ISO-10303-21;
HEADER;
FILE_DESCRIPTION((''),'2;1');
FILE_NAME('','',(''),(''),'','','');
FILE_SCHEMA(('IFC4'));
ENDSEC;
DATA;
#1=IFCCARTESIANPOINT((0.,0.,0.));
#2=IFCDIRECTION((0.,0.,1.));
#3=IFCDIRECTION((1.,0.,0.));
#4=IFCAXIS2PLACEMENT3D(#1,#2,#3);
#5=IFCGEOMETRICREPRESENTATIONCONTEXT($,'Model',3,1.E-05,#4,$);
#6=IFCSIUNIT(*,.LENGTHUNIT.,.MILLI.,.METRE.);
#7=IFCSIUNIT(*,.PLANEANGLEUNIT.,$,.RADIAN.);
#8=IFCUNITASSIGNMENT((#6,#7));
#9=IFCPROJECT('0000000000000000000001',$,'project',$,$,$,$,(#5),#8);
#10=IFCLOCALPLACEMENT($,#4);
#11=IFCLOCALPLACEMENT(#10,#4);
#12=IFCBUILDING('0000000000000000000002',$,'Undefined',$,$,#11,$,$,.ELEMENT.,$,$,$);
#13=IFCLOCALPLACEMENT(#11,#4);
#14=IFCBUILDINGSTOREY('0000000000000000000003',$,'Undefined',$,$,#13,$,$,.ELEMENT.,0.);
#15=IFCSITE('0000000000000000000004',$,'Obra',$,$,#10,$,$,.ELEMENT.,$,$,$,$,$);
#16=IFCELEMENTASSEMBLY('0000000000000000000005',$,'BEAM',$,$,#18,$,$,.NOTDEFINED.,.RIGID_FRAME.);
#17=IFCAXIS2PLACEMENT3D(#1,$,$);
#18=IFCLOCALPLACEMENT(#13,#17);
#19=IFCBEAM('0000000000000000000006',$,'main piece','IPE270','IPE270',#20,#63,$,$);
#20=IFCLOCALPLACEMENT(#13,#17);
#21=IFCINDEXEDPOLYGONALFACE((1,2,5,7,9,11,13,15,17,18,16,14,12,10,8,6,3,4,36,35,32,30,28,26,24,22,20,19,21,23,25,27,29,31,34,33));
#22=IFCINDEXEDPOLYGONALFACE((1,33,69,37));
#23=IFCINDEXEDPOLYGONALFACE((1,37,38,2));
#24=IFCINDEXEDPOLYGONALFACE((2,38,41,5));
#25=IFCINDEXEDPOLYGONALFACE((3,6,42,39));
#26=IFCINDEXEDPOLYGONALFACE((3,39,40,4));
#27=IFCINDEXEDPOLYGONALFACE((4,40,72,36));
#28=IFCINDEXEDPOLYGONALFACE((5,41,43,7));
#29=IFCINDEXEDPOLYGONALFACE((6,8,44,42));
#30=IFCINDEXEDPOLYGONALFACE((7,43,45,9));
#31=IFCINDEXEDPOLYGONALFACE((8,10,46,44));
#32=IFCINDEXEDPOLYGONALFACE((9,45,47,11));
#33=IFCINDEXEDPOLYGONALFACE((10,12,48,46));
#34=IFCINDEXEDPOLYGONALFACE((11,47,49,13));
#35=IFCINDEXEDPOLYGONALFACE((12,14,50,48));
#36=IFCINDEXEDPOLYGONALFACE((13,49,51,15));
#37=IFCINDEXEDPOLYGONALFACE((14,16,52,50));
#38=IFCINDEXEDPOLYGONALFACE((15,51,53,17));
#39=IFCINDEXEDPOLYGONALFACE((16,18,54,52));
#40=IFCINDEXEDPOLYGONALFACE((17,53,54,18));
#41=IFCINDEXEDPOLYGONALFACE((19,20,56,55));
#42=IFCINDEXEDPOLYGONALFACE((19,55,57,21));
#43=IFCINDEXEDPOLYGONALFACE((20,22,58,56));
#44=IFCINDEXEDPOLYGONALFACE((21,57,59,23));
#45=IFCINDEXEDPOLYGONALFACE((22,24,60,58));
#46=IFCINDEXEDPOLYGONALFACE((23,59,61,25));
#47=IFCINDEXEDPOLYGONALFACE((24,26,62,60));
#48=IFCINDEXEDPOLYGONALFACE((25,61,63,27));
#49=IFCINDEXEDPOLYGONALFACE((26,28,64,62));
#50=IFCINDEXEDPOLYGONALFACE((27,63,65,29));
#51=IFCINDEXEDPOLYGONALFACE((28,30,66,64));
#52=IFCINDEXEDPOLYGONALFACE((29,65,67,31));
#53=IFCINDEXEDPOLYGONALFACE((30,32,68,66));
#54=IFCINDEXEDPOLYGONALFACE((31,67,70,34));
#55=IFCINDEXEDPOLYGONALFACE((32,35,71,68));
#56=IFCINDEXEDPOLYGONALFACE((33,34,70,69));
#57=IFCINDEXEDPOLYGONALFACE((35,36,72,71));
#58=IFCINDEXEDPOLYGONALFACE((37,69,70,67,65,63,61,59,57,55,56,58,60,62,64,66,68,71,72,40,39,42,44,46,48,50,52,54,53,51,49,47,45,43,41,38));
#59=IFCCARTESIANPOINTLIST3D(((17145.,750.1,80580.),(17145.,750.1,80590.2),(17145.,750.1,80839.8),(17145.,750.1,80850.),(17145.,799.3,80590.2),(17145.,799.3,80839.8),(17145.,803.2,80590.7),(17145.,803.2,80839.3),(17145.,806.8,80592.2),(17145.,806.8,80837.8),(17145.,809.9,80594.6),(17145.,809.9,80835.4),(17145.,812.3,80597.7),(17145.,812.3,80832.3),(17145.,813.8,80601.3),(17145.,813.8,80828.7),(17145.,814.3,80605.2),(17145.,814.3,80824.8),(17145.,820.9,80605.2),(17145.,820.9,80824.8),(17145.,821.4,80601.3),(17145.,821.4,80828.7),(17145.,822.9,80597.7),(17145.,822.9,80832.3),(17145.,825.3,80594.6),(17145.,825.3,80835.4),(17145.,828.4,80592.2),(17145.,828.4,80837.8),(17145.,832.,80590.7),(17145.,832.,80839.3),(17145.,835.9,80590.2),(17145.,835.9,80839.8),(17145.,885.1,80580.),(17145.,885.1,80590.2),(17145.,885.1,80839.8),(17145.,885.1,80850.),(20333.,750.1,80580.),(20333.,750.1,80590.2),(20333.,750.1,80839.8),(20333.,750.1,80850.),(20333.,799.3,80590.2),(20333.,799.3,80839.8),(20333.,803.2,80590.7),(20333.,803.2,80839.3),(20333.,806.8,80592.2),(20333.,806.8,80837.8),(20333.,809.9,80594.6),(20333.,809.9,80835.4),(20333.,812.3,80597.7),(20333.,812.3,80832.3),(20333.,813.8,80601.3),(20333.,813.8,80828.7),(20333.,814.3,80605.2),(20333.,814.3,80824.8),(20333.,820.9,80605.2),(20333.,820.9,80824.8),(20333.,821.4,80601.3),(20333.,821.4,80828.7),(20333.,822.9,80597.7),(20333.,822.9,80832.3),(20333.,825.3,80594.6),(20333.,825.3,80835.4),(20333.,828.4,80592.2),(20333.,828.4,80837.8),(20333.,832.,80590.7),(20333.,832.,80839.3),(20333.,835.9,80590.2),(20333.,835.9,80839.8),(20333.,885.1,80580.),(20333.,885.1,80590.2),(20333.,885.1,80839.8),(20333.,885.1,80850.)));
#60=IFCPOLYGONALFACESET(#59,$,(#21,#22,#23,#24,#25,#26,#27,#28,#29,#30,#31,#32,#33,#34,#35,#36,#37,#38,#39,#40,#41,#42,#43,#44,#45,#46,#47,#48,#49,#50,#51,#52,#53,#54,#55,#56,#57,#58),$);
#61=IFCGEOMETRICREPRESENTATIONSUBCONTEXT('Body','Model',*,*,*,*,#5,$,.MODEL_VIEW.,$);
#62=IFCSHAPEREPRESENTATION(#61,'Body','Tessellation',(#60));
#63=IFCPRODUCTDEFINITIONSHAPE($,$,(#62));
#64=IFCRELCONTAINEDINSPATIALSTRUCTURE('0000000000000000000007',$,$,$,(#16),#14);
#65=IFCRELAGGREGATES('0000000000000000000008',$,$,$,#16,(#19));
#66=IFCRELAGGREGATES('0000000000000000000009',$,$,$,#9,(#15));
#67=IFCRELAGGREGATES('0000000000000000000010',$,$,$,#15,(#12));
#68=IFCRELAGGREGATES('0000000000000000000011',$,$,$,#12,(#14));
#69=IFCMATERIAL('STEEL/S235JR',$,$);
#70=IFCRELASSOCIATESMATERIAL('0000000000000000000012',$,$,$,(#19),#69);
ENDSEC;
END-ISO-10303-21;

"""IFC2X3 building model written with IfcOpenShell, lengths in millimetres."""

from ifc_helpers import new_model, si_unit, frame, origin_with_axes, origin_2d_with_axis, place, context, subcontext, project, spatial, i_section, extrude, material, element, aggregate, save


model = new_model("IFC2X3")

# Units and contexts
model_context = context("Model", 3, precision=1e-05, world=origin_with_axes())
body_context = subcontext(model_context, "Body", "Model", "MODEL_VIEW")
ifc_project = project(units=[si_unit("LENGTHUNIT", "METRE", prefix="MILLI"), si_unit("PLANEANGLEUNIT", "RADIAN")], contexts=[model_context])

# Site, building, storey
site_placement = place(None, origin_with_axes())
site = spatial("IfcSite", under=ifc_project, at=site_placement, Name="Obra", CompositionType="ELEMENT")
building_placement = place(site_placement, origin_with_axes())
building = spatial("IfcBuilding", under=site, at=building_placement, Name="Undefined", CompositionType="ELEMENT")
storey_placement = place(building_placement, origin_with_axes())
storey = spatial("IfcBuildingStorey", under=building, at=storey_placement, Name="Undefined", CompositionType="ELEMENT", Elevation=0.0)

# Shared definitions
ifc_material = material(Name="STEEL/S235JR")

# Element assembly, beam
assembly_1_placement = place(storey_placement, origin_with_axes())
assembly_1 = element("IfcElementAssembly", 1, at=assembly_1_placement, inside=storey, Name="BEAM", AssemblyPlace="NOTDEFINED", PredefinedType="RIGID_FRAME")
beam_1_placement = place(assembly_1_placement, frame((17145.0, 817.6, 80715.0), z_axis=(0.0, 0.0, 1.0), x_axis=(1.0, 0.0, 0.0)))
beam_1 = element("IfcBeam", 2, at=beam_1_placement, material=ifc_material, Name="main piece", Description="IPE270", ObjectType="IPE270", context=body_context, shape_type="SweptSolid", body=[
    extrude(i_section(OverallWidth=135.0, OverallDepth=270.0, WebThickness=6.6, FlangeThickness=10.2, FilletRadius=15.0, at=origin_2d_with_axis()), frame((3188.0, 0.0, 0.0), z_axis=(-1.0, 0.0, 0.0), x_axis=(0.0, -1.0, 0.0)), (0.0, 0.0, 1.0), 3188.0),
])
aggregate(assembly_1, [beam_1])

save(model, "model.ifc")
